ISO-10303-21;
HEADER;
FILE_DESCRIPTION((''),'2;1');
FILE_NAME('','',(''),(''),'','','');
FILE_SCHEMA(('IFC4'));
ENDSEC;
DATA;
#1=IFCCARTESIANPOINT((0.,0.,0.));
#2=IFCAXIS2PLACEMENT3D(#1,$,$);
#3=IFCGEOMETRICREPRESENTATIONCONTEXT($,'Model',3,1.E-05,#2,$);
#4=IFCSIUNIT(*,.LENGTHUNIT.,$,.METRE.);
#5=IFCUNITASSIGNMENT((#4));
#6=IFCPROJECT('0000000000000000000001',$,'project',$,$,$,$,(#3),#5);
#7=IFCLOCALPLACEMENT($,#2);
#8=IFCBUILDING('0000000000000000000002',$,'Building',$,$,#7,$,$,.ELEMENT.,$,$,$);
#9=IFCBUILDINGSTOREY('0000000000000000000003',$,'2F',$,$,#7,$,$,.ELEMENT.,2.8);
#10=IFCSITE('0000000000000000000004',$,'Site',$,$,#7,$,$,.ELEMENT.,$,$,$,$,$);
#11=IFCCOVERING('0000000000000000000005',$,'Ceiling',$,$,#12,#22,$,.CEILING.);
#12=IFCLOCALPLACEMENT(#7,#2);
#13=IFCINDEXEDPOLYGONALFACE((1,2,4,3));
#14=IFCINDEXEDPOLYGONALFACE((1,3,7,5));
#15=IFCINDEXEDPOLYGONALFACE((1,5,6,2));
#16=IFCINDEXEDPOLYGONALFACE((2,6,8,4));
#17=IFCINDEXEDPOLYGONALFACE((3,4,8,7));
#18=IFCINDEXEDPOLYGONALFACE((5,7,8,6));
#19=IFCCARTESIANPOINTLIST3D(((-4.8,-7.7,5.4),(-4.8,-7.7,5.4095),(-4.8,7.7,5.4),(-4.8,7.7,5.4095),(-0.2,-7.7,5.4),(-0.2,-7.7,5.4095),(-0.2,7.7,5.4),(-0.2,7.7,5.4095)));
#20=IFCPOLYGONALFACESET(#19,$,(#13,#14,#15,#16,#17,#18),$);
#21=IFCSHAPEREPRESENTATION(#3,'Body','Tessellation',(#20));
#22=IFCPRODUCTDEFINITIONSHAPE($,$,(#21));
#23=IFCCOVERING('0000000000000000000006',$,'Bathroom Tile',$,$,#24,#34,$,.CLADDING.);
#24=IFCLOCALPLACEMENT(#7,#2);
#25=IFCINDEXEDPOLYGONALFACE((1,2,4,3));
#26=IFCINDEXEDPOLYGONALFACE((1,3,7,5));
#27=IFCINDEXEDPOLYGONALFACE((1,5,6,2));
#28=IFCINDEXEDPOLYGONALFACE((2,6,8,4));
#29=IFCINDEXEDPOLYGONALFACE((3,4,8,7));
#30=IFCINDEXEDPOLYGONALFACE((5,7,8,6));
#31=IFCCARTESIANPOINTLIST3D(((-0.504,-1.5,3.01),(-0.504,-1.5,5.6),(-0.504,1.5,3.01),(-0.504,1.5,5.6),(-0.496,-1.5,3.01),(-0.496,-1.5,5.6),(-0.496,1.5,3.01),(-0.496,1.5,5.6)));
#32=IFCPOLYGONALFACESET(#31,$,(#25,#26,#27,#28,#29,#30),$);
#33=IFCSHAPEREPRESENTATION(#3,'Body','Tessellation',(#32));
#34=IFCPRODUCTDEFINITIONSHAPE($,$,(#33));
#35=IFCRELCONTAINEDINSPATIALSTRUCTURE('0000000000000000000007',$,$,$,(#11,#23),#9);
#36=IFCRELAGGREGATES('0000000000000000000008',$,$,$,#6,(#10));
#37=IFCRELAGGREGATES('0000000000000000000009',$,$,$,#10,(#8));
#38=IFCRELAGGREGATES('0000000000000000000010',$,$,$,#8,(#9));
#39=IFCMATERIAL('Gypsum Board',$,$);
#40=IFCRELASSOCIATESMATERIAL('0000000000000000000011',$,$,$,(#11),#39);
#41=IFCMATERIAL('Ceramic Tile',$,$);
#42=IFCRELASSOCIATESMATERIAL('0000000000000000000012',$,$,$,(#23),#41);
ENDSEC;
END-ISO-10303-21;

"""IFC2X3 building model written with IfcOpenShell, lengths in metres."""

from ifc_helpers import new_model, si_unit, frame, origin, origin_2d, place, context, project, spatial, rectangle, extrude, material, element, save


model = new_model("IFC2X3")

# Units and contexts
model_context = context("Model", 3, precision=1e-05, world=origin())
ifc_project = project(units=[si_unit("LENGTHUNIT", "METRE")], contexts=[model_context])

# Site, building, storey
placement = place(None, origin())
site = spatial("IfcSite", under=ifc_project, at=placement, Name="Site", CompositionType="ELEMENT")
building = spatial("IfcBuilding", under=site, at=placement, Name="Building", CompositionType="ELEMENT")
storey = spatial("IfcBuildingStorey", under=building, at=placement, Name="2F", CompositionType="ELEMENT", Elevation=2.8)

# Shared definitions
ifc_material_1 = material(Name="Gypsum Board")

# Coverings
ifc_material_2 = material(Name="Ceramic Tile")
covering_1_placement = place(None, frame((-2.5, 0.0, 5.4)))
element("IfcCovering", 1, at=covering_1_placement, inside=storey, material=ifc_material_1, Name="Ceiling", PredefinedType="CEILING", context=model_context, shape_type="SweptSolid", body=[
    extrude(rectangle(XDim=4.6, YDim=15.4, at=origin_2d()), origin(), (0.0, 0.0, 1.0), 0.0095),
])
covering_2_placement = place(None, frame((-0.5, 0.0, 3.01)))
element("IfcCovering", 2, at=covering_2_placement, inside=storey, material=ifc_material_2, Name="Bathroom Tile", PredefinedType="CLADDING", context=model_context, shape_type="SweptSolid", body=[
    extrude(rectangle(XDim=0.008, YDim=3.0, at=origin_2d()), origin(), (0.0, 0.0, 1.0), 2.59),
])

save(model, "model.ifc")
